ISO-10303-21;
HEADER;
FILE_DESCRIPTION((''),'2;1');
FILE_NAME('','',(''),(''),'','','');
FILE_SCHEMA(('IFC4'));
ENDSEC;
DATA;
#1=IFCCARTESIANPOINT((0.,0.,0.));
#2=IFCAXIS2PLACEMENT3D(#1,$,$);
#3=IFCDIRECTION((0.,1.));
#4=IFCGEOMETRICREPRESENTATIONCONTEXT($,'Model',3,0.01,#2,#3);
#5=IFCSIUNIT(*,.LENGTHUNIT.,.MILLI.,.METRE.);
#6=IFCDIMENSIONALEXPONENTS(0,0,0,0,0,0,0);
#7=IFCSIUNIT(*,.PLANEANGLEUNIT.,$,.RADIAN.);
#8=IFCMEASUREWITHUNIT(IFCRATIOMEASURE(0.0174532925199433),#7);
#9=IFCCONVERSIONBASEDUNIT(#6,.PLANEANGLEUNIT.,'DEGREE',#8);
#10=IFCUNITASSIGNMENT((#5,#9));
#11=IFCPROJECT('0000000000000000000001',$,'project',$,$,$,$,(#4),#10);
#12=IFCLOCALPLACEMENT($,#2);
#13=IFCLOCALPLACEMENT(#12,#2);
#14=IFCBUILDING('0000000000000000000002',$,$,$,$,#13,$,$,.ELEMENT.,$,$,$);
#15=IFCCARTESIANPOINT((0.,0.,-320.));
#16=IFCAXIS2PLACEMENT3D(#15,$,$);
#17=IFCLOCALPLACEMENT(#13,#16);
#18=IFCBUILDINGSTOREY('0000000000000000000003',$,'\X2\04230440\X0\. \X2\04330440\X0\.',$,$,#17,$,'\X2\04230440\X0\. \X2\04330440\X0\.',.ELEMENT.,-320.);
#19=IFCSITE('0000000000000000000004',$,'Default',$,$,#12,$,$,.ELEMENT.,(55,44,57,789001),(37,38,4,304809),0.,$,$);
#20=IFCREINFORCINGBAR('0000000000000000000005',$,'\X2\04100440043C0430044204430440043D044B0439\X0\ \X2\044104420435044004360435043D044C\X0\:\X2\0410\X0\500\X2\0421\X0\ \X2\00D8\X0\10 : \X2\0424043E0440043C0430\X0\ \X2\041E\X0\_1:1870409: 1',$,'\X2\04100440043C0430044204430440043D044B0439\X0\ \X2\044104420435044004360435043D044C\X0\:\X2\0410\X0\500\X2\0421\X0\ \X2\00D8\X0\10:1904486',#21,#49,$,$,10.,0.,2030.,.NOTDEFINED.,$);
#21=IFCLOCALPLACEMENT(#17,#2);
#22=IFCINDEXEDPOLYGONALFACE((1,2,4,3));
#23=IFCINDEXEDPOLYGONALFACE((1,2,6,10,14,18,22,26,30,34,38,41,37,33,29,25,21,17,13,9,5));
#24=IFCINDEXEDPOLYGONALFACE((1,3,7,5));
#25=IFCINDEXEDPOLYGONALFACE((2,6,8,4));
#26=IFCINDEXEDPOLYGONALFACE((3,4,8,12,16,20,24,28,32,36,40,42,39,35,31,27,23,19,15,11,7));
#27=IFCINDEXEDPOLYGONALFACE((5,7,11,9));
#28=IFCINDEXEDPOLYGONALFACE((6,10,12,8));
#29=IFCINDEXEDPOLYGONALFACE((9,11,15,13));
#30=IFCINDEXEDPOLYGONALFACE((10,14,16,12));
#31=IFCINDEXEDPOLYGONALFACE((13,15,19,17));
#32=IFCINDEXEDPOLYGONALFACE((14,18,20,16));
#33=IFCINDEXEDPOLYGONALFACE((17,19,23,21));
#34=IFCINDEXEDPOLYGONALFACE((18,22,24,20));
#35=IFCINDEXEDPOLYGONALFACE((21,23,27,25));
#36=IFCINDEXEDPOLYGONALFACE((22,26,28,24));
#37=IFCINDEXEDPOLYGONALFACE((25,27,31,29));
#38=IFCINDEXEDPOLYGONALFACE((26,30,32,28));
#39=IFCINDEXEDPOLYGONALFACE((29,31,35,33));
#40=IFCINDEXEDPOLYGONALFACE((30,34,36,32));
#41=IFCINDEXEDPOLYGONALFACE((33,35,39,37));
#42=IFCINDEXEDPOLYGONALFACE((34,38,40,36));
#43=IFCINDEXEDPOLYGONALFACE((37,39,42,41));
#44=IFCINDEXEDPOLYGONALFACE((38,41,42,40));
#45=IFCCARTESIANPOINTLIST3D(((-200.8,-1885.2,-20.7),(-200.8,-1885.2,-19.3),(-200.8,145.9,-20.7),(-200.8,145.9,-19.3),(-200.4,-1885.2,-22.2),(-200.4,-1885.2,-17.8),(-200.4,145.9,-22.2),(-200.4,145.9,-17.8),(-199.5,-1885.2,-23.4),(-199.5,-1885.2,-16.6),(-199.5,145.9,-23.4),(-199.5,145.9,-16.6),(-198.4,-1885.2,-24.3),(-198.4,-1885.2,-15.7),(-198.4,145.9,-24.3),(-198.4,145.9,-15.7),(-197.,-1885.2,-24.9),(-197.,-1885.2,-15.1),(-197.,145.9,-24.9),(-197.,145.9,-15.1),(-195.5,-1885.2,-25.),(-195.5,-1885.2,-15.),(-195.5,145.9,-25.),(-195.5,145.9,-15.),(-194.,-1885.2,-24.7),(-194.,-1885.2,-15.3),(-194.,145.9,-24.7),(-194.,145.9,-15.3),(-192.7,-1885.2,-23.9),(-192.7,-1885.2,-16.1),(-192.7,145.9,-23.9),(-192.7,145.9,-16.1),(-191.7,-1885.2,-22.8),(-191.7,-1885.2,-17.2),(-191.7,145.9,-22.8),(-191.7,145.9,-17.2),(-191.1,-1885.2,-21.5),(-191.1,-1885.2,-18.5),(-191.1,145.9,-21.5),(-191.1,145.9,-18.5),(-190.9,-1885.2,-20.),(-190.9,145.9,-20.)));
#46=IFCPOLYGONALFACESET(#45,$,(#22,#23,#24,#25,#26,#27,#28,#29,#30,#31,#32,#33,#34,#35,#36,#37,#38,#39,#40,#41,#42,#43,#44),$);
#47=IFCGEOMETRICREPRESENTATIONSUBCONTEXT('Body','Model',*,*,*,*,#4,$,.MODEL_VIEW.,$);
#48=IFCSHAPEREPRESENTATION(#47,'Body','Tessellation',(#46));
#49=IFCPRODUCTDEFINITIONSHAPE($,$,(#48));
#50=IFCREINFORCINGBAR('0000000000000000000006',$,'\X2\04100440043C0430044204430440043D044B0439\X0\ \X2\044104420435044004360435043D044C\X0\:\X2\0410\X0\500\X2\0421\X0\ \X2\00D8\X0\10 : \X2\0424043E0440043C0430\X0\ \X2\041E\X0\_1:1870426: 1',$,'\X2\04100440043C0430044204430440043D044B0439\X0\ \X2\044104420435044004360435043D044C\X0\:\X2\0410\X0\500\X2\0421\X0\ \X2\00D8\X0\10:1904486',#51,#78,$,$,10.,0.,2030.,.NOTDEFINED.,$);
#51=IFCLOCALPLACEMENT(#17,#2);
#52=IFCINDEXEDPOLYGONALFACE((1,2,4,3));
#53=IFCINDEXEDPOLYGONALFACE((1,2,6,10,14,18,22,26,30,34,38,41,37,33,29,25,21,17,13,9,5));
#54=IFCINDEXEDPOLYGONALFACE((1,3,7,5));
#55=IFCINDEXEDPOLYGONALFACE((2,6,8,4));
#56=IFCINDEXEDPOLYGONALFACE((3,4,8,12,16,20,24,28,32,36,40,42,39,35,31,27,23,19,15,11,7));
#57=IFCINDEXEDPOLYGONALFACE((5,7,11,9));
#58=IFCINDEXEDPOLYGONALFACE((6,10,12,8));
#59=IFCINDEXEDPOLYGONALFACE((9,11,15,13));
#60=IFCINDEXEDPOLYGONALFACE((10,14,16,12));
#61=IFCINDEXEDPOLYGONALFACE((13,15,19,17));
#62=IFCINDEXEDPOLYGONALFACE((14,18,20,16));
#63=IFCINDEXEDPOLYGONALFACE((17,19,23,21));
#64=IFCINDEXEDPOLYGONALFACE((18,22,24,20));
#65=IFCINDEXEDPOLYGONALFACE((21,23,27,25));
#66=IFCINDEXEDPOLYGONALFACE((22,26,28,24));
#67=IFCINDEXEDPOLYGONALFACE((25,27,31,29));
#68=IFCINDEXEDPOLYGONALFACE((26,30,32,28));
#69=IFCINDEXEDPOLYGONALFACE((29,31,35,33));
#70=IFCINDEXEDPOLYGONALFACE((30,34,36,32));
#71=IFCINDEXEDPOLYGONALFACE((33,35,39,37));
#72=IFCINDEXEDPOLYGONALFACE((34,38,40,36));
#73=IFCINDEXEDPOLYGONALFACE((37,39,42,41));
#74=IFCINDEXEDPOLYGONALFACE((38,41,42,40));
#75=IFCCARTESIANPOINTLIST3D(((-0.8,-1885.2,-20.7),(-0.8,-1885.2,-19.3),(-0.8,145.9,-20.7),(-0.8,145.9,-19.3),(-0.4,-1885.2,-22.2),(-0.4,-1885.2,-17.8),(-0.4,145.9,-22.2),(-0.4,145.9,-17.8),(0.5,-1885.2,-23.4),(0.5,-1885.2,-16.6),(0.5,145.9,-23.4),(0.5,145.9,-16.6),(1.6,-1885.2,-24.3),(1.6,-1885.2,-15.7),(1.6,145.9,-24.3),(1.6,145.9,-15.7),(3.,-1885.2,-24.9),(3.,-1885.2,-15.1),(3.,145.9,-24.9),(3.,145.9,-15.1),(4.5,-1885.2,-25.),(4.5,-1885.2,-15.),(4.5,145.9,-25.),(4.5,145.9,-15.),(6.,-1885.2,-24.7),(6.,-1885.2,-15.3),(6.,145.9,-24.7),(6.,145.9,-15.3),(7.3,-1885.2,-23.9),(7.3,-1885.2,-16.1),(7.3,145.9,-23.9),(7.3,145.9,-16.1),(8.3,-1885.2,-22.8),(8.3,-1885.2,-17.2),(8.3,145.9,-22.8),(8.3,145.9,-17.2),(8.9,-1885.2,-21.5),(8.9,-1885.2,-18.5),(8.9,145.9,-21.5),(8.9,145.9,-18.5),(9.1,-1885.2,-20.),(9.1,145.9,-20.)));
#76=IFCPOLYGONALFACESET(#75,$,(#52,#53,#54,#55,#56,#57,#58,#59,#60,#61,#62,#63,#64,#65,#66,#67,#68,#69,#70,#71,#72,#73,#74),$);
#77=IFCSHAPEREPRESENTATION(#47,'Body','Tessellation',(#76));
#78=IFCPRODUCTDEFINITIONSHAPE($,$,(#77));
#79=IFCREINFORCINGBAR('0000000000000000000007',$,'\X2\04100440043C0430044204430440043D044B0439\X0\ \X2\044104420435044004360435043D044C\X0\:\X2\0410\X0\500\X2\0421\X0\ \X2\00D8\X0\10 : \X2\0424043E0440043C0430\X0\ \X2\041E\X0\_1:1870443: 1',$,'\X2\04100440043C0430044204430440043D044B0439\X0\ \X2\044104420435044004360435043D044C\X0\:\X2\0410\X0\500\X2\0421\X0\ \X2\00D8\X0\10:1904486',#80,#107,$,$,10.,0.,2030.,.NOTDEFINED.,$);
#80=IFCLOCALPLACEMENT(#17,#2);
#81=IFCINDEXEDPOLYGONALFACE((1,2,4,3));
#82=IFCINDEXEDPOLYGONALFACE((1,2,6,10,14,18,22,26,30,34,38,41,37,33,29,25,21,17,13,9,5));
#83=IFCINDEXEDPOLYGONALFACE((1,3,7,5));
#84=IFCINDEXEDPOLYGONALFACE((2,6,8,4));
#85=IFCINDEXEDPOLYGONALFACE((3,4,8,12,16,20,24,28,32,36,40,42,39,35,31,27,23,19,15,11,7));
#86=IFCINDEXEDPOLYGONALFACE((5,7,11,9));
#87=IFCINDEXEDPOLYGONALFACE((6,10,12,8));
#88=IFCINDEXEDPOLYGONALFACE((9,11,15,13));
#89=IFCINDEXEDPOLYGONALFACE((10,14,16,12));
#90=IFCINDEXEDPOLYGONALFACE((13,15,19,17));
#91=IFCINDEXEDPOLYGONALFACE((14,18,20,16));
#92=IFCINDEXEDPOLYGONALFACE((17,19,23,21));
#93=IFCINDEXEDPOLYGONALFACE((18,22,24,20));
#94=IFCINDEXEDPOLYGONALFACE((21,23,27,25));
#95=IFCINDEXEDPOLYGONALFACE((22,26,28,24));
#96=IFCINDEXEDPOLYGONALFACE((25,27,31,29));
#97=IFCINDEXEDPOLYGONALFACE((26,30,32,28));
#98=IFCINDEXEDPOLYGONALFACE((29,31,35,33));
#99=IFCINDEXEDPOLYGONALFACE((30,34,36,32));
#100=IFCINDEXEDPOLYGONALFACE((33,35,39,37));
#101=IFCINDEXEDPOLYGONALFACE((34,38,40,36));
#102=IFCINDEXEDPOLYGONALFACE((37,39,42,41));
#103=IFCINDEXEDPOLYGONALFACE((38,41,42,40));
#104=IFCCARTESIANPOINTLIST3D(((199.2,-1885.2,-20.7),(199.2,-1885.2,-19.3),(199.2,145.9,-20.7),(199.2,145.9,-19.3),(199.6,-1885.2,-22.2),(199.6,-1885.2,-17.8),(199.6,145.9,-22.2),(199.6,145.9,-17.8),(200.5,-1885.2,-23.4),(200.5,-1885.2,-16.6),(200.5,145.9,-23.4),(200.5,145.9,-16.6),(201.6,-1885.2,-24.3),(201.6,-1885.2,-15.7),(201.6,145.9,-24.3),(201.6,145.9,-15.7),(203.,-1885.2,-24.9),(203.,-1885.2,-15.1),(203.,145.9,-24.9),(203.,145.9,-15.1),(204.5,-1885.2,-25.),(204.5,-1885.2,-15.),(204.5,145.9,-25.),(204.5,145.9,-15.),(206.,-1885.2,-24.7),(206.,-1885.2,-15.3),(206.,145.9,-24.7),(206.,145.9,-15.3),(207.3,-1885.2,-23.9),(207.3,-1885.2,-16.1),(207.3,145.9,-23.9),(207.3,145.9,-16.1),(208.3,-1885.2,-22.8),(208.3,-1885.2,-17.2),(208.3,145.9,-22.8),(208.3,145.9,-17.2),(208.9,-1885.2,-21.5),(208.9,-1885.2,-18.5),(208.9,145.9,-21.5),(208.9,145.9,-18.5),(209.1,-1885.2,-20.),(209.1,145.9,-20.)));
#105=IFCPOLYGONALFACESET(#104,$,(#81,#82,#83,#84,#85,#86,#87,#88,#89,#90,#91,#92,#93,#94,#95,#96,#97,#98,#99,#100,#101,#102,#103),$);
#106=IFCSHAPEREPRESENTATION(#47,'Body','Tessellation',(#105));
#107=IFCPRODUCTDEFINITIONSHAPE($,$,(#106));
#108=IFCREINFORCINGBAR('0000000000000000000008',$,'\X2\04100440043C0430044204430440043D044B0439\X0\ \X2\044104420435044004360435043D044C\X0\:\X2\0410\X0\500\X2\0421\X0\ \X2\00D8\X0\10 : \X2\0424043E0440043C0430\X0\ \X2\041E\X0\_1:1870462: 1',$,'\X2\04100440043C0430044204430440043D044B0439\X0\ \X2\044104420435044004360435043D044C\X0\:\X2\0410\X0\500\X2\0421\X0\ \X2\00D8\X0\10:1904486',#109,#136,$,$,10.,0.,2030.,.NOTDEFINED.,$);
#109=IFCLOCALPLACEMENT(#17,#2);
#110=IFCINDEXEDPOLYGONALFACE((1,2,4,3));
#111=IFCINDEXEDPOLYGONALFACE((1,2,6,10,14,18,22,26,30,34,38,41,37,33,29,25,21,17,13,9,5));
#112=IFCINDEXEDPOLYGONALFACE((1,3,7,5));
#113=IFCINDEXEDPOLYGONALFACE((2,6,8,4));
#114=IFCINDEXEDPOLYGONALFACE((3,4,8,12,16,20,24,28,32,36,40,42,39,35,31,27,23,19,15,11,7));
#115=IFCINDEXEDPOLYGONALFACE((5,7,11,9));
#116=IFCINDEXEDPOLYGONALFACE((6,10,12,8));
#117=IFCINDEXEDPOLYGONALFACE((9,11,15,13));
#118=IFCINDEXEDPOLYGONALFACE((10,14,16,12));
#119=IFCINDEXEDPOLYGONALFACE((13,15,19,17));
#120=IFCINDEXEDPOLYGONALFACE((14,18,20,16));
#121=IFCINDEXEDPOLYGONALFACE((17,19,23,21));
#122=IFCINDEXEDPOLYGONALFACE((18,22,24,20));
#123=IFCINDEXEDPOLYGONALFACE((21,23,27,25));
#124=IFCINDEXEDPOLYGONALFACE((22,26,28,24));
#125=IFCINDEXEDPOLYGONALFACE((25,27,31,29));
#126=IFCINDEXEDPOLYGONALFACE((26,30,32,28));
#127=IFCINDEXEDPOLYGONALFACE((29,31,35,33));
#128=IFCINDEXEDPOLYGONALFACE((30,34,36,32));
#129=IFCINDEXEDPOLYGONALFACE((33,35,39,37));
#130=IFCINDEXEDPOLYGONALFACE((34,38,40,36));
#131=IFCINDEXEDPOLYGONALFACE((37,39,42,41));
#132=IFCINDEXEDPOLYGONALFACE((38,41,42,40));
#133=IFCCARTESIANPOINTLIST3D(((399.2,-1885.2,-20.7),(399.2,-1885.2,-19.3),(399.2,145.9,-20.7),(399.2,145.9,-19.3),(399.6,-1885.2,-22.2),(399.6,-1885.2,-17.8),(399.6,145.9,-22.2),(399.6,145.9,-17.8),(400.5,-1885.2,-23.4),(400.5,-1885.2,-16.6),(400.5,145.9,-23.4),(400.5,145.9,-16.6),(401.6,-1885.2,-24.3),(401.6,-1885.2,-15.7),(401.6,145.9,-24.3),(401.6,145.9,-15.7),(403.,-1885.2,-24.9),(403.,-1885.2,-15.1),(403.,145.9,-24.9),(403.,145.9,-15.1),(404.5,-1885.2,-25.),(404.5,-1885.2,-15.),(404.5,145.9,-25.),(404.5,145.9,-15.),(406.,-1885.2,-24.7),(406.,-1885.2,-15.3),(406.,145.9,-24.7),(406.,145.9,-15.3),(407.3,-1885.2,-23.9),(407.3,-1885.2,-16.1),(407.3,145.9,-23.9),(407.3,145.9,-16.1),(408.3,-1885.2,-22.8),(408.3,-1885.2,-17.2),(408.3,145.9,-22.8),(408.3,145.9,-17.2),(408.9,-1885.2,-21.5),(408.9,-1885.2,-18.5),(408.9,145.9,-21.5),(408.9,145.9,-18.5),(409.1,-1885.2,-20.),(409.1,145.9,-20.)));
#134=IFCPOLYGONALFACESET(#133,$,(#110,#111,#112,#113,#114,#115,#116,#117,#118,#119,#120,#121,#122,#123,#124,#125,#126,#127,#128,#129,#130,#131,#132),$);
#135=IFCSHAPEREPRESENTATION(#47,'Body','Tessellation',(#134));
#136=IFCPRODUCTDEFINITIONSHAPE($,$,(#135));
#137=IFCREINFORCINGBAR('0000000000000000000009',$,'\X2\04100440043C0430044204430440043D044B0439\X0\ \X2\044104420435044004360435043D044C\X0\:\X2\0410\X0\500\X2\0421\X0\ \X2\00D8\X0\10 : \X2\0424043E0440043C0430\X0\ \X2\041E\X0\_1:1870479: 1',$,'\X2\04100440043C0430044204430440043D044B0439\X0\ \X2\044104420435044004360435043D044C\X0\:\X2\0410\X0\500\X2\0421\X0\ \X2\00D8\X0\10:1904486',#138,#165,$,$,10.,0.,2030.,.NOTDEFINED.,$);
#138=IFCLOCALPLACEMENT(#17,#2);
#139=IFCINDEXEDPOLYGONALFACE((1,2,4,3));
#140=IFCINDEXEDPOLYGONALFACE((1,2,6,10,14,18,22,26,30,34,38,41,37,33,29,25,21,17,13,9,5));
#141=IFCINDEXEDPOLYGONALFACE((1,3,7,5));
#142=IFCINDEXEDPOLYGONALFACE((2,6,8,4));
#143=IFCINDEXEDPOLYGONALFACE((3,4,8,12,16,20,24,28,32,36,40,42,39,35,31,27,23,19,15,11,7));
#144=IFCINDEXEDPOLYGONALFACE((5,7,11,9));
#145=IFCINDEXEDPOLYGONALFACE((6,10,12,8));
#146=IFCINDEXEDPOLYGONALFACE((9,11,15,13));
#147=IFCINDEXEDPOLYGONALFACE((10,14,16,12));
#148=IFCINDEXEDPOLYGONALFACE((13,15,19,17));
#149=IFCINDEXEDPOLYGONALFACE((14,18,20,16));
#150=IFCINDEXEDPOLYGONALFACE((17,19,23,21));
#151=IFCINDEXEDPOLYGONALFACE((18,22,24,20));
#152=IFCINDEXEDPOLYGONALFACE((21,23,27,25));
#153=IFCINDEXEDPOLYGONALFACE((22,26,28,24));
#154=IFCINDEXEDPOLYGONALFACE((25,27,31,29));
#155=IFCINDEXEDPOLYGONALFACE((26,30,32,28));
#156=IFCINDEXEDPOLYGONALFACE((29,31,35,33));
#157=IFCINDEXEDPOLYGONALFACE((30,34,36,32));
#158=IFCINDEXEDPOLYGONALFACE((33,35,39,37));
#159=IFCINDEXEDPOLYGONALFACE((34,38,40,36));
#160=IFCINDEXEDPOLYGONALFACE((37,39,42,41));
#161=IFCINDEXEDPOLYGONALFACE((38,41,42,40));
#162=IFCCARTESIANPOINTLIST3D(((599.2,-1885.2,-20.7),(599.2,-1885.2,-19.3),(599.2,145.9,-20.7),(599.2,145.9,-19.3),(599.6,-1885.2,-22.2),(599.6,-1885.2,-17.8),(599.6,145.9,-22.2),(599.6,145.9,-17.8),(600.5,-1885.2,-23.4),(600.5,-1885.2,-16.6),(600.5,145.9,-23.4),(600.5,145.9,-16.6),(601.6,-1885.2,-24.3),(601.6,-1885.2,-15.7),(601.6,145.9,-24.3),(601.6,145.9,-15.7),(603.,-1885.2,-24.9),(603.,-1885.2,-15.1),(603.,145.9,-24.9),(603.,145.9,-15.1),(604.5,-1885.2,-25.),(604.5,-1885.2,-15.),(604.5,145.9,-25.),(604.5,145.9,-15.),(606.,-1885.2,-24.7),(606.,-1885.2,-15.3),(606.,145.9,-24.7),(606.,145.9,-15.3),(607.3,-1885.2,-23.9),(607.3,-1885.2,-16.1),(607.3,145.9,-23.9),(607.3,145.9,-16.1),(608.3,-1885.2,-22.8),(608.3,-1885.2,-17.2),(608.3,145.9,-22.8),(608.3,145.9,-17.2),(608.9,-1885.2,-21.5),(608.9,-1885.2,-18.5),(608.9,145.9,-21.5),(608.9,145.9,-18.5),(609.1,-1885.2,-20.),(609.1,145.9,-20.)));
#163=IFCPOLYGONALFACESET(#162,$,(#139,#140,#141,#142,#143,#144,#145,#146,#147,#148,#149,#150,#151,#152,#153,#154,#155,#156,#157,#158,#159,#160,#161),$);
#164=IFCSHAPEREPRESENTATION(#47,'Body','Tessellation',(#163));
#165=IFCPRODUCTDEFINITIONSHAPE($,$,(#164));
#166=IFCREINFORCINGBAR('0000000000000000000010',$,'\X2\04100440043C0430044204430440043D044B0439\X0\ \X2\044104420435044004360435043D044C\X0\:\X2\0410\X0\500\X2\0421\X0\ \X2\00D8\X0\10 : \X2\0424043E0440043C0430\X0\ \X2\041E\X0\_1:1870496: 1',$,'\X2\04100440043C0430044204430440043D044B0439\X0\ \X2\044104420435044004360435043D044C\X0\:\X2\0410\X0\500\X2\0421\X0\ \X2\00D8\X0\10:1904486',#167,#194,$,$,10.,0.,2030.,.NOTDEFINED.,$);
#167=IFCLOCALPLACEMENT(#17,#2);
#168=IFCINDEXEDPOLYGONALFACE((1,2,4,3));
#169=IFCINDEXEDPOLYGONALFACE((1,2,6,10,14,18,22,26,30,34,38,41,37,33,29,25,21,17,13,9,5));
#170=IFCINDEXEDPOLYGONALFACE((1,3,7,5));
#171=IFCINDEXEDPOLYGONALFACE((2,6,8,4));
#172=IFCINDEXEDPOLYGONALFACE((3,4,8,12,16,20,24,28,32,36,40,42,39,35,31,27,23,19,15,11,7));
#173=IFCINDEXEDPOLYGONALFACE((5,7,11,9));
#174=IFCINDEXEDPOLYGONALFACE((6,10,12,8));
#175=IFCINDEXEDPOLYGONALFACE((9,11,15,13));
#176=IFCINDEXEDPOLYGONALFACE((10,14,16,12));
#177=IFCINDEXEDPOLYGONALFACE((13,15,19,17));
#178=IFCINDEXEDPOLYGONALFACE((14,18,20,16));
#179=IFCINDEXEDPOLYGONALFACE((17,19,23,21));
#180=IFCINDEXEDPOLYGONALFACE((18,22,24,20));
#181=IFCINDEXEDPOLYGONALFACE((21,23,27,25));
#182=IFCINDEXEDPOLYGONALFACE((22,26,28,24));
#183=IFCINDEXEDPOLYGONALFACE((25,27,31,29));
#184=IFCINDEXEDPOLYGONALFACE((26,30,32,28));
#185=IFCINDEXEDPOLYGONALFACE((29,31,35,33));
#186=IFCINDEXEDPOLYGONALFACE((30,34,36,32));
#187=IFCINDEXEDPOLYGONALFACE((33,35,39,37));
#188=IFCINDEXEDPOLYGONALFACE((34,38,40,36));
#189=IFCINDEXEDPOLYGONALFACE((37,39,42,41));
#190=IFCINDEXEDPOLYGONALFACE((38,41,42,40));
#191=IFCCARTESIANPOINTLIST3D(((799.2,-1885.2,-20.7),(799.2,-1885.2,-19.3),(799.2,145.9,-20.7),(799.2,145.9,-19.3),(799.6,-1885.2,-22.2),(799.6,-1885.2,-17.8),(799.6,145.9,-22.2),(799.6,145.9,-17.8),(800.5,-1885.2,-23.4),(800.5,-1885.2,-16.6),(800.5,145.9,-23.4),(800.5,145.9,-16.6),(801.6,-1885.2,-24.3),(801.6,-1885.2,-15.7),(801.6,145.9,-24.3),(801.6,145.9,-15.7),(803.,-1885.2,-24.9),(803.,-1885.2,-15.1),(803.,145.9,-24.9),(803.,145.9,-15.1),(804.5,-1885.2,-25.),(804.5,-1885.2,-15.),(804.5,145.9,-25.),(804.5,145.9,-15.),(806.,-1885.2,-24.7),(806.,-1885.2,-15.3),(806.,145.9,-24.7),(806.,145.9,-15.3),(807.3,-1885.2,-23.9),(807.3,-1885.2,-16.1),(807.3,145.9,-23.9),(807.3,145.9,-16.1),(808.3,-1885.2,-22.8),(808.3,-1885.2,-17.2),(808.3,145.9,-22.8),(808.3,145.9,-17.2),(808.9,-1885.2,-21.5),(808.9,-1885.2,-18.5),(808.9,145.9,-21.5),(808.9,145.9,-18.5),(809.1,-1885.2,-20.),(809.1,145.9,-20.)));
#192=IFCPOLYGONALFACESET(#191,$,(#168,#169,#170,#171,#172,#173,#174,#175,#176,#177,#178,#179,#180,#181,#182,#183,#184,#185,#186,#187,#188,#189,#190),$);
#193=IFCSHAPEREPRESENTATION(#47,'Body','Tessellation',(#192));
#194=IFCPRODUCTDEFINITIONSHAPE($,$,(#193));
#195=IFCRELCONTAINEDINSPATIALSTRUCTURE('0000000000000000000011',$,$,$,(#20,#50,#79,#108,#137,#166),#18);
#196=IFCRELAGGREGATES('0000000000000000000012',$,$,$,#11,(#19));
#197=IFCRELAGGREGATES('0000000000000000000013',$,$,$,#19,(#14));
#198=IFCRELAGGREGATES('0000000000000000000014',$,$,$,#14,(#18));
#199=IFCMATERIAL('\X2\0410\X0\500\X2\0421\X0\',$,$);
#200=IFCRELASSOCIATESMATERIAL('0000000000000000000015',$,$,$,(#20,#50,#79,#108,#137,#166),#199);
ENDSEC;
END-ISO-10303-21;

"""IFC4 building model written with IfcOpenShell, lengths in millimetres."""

from ifc_helpers import new_model, entity, si_unit, converted_unit, direction, frame, origin, place, context, subcontext, project, spatial, material, element, save


model = new_model("IFC4")

# Units and contexts
model_context = context("Model", 3, precision=0.01, world=origin(), true_north=direction((0.0, 1.0)))
body_context = subcontext(model_context, "Body", "Model", "MODEL_VIEW")
ifc_project = project(units=[si_unit("LENGTHUNIT", "METRE", prefix="MILLI"), converted_unit("PLANEANGLEUNIT", "DEGREE", entity("IfcRatioMeasure", 0.0174532925199433), si_unit("PLANEANGLEUNIT", "RADIAN"), dimensions=[0, 0, 0, 0, 0, 0, 0])], contexts=[model_context])

# Site, building, storey
site_placement = place(None, origin())
site = spatial("IfcSite", under=ifc_project, at=site_placement, Name="Default", CompositionType="ELEMENT", RefLatitude=(55, 44, 57, 789001), RefLongitude=(37, 38, 4, 304809), RefElevation=0.0)
building_placement = place(site_placement, origin())
building = spatial("IfcBuilding", under=site, at=building_placement, CompositionType="ELEMENT")
storey_placement = place(building_placement, frame((0.0, 0.0, -320.0)))
storey = spatial("IfcBuildingStorey", under=building, at=storey_placement, Name="Ур. гр.", LongName="Ур. гр.", CompositionType="ELEMENT", Elevation=-320.0)

# Reinforcing bars
ifc_material_1 = material(Name="А500С")
reinforcing_bar_1_placement = place(storey_placement, origin())
element("IfcReinforcingBar", 1, at=reinforcing_bar_1_placement, inside=storey, material=ifc_material_1, Name="Арматурный стержень:А500С Ø10 : Форма О_1:1870409: 1", ObjectType="Арматурный стержень:А500С Ø10:1904486", BarLength=2030.0, CrossSectionArea=0.0, NominalDiameter=10.0, PredefinedType="NOTDEFINED", context=body_context, shape_type="AdvancedSweptSolid", body=[
    entity("IfcSweptDiskSolid", entity("IfcCompositeCurve", [entity("IfcCompositeCurveSegment", "CONTINUOUS", True, entity("IfcPolyline", [entity("IfcCartesianPoint", [-195.9, -1885.2, -20.0]), entity("IfcCartesianPoint", [-195.9, 145.9, -20.0])]))], False), 5.0, None, 0.0, 1.0),
])
reinforcing_bar_2_placement = place(storey_placement, origin())
element("IfcReinforcingBar", 2, at=reinforcing_bar_2_placement, inside=storey, material=ifc_material_1, Name="Арматурный стержень:А500С Ø10 : Форма О_1:1870426: 1", ObjectType="Арматурный стержень:А500С Ø10:1904486", BarLength=2030.0, CrossSectionArea=0.0, NominalDiameter=10.0, PredefinedType="NOTDEFINED", context=body_context, shape_type="AdvancedSweptSolid", body=[
    entity("IfcSweptDiskSolid", entity("IfcCompositeCurve", [entity("IfcCompositeCurveSegment", "CONTINUOUS", True, entity("IfcPolyline", [entity("IfcCartesianPoint", [4.1, -1885.2, -20.0]), entity("IfcCartesianPoint", [4.1, 145.9, -20.0])]))], False), 5.0, None, 0.0, 1.0),
])
reinforcing_bar_3_placement = place(storey_placement, origin())
element("IfcReinforcingBar", 3, at=reinforcing_bar_3_placement, inside=storey, material=ifc_material_1, Name="Арматурный стержень:А500С Ø10 : Форма О_1:1870443: 1", ObjectType="Арматурный стержень:А500С Ø10:1904486", BarLength=2030.0, CrossSectionArea=0.0, NominalDiameter=10.0, PredefinedType="NOTDEFINED", context=body_context, shape_type="AdvancedSweptSolid", body=[
    entity("IfcSweptDiskSolid", entity("IfcCompositeCurve", [entity("IfcCompositeCurveSegment", "CONTINUOUS", True, entity("IfcPolyline", [entity("IfcCartesianPoint", [204.1, -1885.2, -20.0]), entity("IfcCartesianPoint", [204.1, 145.9, -20.0])]))], False), 5.0, None, 0.0, 1.0),
])
reinforcing_bar_4_placement = place(storey_placement, origin())
element("IfcReinforcingBar", 4, at=reinforcing_bar_4_placement, inside=storey, material=ifc_material_1, Name="Арматурный стержень:А500С Ø10 : Форма О_1:1870462: 1", ObjectType="Арматурный стержень:А500С Ø10:1904486", BarLength=2030.0, CrossSectionArea=0.0, NominalDiameter=10.0, PredefinedType="NOTDEFINED", context=body_context, shape_type="AdvancedSweptSolid", body=[
    entity("IfcSweptDiskSolid", entity("IfcCompositeCurve", [entity("IfcCompositeCurveSegment", "CONTINUOUS", True, entity("IfcPolyline", [entity("IfcCartesianPoint", [404.1, -1885.2, -20.0]), entity("IfcCartesianPoint", [404.1, 145.9, -20.0])]))], False), 5.0, None, 0.0, 1.0),
])
reinforcing_bar_5_placement = place(storey_placement, origin())
element("IfcReinforcingBar", 5, at=reinforcing_bar_5_placement, inside=storey, material=ifc_material_1, Name="Арматурный стержень:А500С Ø10 : Форма О_1:1870479: 1", ObjectType="Арматурный стержень:А500С Ø10:1904486", BarLength=2030.0, CrossSectionArea=0.0, NominalDiameter=10.0, PredefinedType="NOTDEFINED", context=body_context, shape_type="AdvancedSweptSolid", body=[
    entity("IfcSweptDiskSolid", entity("IfcCompositeCurve", [entity("IfcCompositeCurveSegment", "CONTINUOUS", True, entity("IfcPolyline", [entity("IfcCartesianPoint", [604.1, -1885.2, -20.0]), entity("IfcCartesianPoint", [604.1, 145.9, -20.0])]))], False), 5.0, None, 0.0, 1.0),
])
reinforcing_bar_6_placement = place(storey_placement, origin())
element("IfcReinforcingBar", 6, at=reinforcing_bar_6_placement, inside=storey, material=ifc_material_1, Name="Арматурный стержень:А500С Ø10 : Форма О_1:1870496: 1", ObjectType="Арматурный стержень:А500С Ø10:1904486", BarLength=2030.0, CrossSectionArea=0.0, NominalDiameter=10.0, PredefinedType="NOTDEFINED", context=body_context, shape_type="AdvancedSweptSolid", body=[
    entity("IfcSweptDiskSolid", entity("IfcCompositeCurve", [entity("IfcCompositeCurveSegment", "CONTINUOUS", True, entity("IfcPolyline", [entity("IfcCartesianPoint", [804.1, -1885.2, -20.0]), entity("IfcCartesianPoint", [804.1, 145.9, -20.0])]))], False), 5.0, None, 0.0, 1.0),
])

save(model, "model.ifc")
